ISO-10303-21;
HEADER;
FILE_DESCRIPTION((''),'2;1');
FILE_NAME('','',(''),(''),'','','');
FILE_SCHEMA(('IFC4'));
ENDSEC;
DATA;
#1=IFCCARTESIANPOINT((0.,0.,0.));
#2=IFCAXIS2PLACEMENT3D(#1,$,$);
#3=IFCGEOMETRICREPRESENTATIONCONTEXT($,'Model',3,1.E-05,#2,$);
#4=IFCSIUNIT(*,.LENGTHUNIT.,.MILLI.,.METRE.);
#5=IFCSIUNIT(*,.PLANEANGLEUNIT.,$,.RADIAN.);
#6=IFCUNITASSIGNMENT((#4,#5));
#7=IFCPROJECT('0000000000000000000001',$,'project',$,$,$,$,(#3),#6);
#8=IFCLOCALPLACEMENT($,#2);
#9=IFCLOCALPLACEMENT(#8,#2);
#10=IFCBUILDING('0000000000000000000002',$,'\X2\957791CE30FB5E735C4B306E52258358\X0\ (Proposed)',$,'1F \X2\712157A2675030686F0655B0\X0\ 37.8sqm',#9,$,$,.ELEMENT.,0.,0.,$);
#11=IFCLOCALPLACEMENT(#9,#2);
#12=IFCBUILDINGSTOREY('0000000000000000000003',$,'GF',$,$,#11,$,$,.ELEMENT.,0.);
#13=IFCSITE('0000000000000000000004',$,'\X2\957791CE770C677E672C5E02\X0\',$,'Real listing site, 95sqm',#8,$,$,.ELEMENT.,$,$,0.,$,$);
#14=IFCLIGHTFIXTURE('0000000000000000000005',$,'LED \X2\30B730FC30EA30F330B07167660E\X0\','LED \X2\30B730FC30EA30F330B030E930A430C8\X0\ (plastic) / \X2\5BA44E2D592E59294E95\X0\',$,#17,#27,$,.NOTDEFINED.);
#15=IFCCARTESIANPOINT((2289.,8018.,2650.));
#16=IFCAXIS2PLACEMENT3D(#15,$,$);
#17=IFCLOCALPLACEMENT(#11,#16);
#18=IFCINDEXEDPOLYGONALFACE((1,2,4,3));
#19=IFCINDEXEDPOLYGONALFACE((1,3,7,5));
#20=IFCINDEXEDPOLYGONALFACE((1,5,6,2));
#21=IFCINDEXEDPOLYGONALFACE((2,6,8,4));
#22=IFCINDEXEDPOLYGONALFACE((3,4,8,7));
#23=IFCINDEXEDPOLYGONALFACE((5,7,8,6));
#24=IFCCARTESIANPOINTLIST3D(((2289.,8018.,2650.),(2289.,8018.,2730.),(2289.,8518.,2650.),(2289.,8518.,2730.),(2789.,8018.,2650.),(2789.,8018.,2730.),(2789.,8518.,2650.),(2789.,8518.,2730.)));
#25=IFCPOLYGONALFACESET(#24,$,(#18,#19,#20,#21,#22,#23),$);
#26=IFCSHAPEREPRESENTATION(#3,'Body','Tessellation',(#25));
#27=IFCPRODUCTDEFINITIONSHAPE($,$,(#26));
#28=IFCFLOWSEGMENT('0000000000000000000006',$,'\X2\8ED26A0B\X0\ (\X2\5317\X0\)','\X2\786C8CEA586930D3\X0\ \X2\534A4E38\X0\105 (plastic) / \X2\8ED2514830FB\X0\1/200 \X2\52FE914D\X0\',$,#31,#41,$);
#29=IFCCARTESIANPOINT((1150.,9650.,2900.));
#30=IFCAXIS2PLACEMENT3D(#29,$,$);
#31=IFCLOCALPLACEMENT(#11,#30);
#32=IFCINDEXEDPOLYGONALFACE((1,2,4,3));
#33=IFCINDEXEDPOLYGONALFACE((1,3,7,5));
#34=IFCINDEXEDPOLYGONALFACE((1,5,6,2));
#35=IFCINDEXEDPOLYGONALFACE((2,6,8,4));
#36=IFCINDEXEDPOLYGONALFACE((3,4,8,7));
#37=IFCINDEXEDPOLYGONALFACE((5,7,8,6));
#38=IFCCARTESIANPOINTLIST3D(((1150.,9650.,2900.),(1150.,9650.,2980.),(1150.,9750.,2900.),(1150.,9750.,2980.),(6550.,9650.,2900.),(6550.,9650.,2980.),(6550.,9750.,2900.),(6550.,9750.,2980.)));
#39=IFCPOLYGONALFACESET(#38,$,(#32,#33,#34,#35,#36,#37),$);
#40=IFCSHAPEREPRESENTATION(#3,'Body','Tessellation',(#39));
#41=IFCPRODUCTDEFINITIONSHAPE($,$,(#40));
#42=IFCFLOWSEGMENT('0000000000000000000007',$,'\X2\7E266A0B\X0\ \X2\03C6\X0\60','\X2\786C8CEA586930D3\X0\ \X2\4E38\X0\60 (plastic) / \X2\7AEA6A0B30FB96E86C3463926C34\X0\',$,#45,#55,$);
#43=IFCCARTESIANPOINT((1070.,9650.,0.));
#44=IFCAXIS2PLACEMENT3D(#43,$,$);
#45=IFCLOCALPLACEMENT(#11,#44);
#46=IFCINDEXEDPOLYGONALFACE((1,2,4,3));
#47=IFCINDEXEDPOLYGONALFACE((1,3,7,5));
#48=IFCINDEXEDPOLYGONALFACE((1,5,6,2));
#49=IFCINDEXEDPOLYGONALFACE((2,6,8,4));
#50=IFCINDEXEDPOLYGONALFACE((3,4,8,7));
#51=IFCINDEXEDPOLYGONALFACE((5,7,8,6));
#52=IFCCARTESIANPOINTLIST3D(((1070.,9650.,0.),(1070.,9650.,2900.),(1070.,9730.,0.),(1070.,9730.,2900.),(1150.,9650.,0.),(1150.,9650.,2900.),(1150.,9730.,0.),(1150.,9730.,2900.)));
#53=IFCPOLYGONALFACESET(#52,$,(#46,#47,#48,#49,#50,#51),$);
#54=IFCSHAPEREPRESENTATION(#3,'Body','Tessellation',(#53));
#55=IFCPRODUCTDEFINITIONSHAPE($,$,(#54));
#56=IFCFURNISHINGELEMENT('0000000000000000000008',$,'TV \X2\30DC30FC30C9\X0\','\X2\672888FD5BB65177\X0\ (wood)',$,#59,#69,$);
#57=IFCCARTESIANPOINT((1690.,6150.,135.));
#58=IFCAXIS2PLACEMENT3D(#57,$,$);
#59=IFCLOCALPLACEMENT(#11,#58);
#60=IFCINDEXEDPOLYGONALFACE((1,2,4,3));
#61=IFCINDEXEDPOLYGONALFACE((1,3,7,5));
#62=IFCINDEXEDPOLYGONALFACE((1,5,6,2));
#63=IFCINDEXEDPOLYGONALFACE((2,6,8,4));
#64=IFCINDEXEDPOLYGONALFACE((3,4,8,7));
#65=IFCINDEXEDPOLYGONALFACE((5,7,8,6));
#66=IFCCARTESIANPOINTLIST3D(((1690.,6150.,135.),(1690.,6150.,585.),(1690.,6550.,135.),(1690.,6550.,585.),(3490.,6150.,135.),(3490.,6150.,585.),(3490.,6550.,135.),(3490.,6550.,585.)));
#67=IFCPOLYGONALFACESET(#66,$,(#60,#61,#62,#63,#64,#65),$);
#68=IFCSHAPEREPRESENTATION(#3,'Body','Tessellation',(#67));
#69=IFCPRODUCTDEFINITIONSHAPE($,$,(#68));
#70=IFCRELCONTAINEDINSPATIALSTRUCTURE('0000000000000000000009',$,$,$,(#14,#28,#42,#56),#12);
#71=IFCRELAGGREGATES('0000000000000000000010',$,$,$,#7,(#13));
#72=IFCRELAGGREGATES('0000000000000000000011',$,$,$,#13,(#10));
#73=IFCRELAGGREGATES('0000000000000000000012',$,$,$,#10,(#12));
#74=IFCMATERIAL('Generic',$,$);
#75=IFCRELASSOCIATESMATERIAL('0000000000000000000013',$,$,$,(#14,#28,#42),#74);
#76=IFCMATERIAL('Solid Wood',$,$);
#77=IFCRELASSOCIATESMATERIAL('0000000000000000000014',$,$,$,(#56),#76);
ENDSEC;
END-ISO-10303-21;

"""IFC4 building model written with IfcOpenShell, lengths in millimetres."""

from ifc_helpers import new_model, si_unit, frame, frame_2d, origin, place, context, project, spatial, rectangle, extrude, material, element, save


model = new_model("IFC4")

# Units and contexts
model_context = context("Model", 3, precision=1e-05, world=origin())
ifc_project = project(units=[si_unit("LENGTHUNIT", "METRE", prefix="MILLI"), si_unit("PLANEANGLEUNIT", "RADIAN")], contexts=[model_context])

# Site, building, storey
site_placement = place(None, origin())
site = spatial("IfcSite", under=ifc_project, at=site_placement, Name="長野県松本市", ObjectType="Real listing site, 95sqm", CompositionType="ELEMENT", RefElevation=0.0)
building_placement = place(site_placement, origin())
building = spatial("IfcBuilding", under=site, at=building_placement, Name="長野・平屋の別荘 (Proposed)", ObjectType="1F 無垢材と漆喰 37.8sqm", CompositionType="ELEMENT", ElevationOfRefHeight=0.0, ElevationOfTerrain=0.0)
storey_placement = place(building_placement, origin())
storey = spatial("IfcBuildingStorey", under=building, at=storey_placement, Name="GF", CompositionType="ELEMENT", Elevation=0.0)

# Shared definitions
ifc_material_1 = material(Name="Solid Wood")

# Shared definitions
ifc_material_2 = material(Name="Generic")

# Light fixture
light_fixture_placement = place(storey_placement, frame((2289.0, 8018.0, 2650.0)))
element("IfcLightFixture", 1, at=light_fixture_placement, inside=storey, material=ifc_material_2, Name="LED シーリング照明", Description="LED シーリングライト (plastic) / 室中央天井", PredefinedType="NOTDEFINED", context=model_context, shape_type="SweptSolid", body=[
    extrude(rectangle(XDim=500.0, YDim=500.0, at=frame_2d((250.0, 250.0))), frame((2289.0, 8018.0, 2650.0)), (0.0, 0.0, 1.0), 80.0),
])

# Flow segments
flow_segment_1_placement = place(storey_placement, frame((1150.0, 9650.0, 2900.0)))
element("IfcFlowSegment", 2, at=flow_segment_1_placement, inside=storey, material=ifc_material_2, Name="軒樋 (北)", Description="硬質塩ビ 半丸105 (plastic) / 軒先・1/200 勾配", context=model_context, shape_type="SweptSolid", body=[
    extrude(rectangle(XDim=5400.0, YDim=100.0, at=frame_2d((2700.0, 50.0))), frame((1150.0, 9650.0, 2900.0)), (0.0, 0.0, 1.0), 80.0),
])
flow_segment_2_placement = place(storey_placement, frame((1070.0, 9650.0, 0.0)))
element("IfcFlowSegment", 3, at=flow_segment_2_placement, inside=storey, material=ifc_material_2, Name="縦樋 φ60", Description="硬質塩ビ 丸60 (plastic) / 竪樋・雨水排水", context=model_context, shape_type="SweptSolid", body=[
    extrude(rectangle(XDim=80.0, YDim=80.0, at=frame_2d((40.0, 40.0))), frame((1070.0, 9650.0, 0.0)), (0.0, 0.0, 1.0), 2900.0),
])

# Furnishing element
furnishing_placement = place(storey_placement, frame((1690.0, 6150.0, 135.0)))
element("IfcFurnishingElement", 4, at=furnishing_placement, inside=storey, material=ifc_material_1, Name="TV ボード", Description="木製家具 (wood)", context=model_context, shape_type="SweptSolid", body=[
    extrude(rectangle(XDim=1800.0, YDim=400.0, at=frame_2d((900.0, 200.0))), frame((1690.0, 6150.0, 135.0)), (0.0, 0.0, 1.0), 450.0),
])

save(model, "model.ifc")
